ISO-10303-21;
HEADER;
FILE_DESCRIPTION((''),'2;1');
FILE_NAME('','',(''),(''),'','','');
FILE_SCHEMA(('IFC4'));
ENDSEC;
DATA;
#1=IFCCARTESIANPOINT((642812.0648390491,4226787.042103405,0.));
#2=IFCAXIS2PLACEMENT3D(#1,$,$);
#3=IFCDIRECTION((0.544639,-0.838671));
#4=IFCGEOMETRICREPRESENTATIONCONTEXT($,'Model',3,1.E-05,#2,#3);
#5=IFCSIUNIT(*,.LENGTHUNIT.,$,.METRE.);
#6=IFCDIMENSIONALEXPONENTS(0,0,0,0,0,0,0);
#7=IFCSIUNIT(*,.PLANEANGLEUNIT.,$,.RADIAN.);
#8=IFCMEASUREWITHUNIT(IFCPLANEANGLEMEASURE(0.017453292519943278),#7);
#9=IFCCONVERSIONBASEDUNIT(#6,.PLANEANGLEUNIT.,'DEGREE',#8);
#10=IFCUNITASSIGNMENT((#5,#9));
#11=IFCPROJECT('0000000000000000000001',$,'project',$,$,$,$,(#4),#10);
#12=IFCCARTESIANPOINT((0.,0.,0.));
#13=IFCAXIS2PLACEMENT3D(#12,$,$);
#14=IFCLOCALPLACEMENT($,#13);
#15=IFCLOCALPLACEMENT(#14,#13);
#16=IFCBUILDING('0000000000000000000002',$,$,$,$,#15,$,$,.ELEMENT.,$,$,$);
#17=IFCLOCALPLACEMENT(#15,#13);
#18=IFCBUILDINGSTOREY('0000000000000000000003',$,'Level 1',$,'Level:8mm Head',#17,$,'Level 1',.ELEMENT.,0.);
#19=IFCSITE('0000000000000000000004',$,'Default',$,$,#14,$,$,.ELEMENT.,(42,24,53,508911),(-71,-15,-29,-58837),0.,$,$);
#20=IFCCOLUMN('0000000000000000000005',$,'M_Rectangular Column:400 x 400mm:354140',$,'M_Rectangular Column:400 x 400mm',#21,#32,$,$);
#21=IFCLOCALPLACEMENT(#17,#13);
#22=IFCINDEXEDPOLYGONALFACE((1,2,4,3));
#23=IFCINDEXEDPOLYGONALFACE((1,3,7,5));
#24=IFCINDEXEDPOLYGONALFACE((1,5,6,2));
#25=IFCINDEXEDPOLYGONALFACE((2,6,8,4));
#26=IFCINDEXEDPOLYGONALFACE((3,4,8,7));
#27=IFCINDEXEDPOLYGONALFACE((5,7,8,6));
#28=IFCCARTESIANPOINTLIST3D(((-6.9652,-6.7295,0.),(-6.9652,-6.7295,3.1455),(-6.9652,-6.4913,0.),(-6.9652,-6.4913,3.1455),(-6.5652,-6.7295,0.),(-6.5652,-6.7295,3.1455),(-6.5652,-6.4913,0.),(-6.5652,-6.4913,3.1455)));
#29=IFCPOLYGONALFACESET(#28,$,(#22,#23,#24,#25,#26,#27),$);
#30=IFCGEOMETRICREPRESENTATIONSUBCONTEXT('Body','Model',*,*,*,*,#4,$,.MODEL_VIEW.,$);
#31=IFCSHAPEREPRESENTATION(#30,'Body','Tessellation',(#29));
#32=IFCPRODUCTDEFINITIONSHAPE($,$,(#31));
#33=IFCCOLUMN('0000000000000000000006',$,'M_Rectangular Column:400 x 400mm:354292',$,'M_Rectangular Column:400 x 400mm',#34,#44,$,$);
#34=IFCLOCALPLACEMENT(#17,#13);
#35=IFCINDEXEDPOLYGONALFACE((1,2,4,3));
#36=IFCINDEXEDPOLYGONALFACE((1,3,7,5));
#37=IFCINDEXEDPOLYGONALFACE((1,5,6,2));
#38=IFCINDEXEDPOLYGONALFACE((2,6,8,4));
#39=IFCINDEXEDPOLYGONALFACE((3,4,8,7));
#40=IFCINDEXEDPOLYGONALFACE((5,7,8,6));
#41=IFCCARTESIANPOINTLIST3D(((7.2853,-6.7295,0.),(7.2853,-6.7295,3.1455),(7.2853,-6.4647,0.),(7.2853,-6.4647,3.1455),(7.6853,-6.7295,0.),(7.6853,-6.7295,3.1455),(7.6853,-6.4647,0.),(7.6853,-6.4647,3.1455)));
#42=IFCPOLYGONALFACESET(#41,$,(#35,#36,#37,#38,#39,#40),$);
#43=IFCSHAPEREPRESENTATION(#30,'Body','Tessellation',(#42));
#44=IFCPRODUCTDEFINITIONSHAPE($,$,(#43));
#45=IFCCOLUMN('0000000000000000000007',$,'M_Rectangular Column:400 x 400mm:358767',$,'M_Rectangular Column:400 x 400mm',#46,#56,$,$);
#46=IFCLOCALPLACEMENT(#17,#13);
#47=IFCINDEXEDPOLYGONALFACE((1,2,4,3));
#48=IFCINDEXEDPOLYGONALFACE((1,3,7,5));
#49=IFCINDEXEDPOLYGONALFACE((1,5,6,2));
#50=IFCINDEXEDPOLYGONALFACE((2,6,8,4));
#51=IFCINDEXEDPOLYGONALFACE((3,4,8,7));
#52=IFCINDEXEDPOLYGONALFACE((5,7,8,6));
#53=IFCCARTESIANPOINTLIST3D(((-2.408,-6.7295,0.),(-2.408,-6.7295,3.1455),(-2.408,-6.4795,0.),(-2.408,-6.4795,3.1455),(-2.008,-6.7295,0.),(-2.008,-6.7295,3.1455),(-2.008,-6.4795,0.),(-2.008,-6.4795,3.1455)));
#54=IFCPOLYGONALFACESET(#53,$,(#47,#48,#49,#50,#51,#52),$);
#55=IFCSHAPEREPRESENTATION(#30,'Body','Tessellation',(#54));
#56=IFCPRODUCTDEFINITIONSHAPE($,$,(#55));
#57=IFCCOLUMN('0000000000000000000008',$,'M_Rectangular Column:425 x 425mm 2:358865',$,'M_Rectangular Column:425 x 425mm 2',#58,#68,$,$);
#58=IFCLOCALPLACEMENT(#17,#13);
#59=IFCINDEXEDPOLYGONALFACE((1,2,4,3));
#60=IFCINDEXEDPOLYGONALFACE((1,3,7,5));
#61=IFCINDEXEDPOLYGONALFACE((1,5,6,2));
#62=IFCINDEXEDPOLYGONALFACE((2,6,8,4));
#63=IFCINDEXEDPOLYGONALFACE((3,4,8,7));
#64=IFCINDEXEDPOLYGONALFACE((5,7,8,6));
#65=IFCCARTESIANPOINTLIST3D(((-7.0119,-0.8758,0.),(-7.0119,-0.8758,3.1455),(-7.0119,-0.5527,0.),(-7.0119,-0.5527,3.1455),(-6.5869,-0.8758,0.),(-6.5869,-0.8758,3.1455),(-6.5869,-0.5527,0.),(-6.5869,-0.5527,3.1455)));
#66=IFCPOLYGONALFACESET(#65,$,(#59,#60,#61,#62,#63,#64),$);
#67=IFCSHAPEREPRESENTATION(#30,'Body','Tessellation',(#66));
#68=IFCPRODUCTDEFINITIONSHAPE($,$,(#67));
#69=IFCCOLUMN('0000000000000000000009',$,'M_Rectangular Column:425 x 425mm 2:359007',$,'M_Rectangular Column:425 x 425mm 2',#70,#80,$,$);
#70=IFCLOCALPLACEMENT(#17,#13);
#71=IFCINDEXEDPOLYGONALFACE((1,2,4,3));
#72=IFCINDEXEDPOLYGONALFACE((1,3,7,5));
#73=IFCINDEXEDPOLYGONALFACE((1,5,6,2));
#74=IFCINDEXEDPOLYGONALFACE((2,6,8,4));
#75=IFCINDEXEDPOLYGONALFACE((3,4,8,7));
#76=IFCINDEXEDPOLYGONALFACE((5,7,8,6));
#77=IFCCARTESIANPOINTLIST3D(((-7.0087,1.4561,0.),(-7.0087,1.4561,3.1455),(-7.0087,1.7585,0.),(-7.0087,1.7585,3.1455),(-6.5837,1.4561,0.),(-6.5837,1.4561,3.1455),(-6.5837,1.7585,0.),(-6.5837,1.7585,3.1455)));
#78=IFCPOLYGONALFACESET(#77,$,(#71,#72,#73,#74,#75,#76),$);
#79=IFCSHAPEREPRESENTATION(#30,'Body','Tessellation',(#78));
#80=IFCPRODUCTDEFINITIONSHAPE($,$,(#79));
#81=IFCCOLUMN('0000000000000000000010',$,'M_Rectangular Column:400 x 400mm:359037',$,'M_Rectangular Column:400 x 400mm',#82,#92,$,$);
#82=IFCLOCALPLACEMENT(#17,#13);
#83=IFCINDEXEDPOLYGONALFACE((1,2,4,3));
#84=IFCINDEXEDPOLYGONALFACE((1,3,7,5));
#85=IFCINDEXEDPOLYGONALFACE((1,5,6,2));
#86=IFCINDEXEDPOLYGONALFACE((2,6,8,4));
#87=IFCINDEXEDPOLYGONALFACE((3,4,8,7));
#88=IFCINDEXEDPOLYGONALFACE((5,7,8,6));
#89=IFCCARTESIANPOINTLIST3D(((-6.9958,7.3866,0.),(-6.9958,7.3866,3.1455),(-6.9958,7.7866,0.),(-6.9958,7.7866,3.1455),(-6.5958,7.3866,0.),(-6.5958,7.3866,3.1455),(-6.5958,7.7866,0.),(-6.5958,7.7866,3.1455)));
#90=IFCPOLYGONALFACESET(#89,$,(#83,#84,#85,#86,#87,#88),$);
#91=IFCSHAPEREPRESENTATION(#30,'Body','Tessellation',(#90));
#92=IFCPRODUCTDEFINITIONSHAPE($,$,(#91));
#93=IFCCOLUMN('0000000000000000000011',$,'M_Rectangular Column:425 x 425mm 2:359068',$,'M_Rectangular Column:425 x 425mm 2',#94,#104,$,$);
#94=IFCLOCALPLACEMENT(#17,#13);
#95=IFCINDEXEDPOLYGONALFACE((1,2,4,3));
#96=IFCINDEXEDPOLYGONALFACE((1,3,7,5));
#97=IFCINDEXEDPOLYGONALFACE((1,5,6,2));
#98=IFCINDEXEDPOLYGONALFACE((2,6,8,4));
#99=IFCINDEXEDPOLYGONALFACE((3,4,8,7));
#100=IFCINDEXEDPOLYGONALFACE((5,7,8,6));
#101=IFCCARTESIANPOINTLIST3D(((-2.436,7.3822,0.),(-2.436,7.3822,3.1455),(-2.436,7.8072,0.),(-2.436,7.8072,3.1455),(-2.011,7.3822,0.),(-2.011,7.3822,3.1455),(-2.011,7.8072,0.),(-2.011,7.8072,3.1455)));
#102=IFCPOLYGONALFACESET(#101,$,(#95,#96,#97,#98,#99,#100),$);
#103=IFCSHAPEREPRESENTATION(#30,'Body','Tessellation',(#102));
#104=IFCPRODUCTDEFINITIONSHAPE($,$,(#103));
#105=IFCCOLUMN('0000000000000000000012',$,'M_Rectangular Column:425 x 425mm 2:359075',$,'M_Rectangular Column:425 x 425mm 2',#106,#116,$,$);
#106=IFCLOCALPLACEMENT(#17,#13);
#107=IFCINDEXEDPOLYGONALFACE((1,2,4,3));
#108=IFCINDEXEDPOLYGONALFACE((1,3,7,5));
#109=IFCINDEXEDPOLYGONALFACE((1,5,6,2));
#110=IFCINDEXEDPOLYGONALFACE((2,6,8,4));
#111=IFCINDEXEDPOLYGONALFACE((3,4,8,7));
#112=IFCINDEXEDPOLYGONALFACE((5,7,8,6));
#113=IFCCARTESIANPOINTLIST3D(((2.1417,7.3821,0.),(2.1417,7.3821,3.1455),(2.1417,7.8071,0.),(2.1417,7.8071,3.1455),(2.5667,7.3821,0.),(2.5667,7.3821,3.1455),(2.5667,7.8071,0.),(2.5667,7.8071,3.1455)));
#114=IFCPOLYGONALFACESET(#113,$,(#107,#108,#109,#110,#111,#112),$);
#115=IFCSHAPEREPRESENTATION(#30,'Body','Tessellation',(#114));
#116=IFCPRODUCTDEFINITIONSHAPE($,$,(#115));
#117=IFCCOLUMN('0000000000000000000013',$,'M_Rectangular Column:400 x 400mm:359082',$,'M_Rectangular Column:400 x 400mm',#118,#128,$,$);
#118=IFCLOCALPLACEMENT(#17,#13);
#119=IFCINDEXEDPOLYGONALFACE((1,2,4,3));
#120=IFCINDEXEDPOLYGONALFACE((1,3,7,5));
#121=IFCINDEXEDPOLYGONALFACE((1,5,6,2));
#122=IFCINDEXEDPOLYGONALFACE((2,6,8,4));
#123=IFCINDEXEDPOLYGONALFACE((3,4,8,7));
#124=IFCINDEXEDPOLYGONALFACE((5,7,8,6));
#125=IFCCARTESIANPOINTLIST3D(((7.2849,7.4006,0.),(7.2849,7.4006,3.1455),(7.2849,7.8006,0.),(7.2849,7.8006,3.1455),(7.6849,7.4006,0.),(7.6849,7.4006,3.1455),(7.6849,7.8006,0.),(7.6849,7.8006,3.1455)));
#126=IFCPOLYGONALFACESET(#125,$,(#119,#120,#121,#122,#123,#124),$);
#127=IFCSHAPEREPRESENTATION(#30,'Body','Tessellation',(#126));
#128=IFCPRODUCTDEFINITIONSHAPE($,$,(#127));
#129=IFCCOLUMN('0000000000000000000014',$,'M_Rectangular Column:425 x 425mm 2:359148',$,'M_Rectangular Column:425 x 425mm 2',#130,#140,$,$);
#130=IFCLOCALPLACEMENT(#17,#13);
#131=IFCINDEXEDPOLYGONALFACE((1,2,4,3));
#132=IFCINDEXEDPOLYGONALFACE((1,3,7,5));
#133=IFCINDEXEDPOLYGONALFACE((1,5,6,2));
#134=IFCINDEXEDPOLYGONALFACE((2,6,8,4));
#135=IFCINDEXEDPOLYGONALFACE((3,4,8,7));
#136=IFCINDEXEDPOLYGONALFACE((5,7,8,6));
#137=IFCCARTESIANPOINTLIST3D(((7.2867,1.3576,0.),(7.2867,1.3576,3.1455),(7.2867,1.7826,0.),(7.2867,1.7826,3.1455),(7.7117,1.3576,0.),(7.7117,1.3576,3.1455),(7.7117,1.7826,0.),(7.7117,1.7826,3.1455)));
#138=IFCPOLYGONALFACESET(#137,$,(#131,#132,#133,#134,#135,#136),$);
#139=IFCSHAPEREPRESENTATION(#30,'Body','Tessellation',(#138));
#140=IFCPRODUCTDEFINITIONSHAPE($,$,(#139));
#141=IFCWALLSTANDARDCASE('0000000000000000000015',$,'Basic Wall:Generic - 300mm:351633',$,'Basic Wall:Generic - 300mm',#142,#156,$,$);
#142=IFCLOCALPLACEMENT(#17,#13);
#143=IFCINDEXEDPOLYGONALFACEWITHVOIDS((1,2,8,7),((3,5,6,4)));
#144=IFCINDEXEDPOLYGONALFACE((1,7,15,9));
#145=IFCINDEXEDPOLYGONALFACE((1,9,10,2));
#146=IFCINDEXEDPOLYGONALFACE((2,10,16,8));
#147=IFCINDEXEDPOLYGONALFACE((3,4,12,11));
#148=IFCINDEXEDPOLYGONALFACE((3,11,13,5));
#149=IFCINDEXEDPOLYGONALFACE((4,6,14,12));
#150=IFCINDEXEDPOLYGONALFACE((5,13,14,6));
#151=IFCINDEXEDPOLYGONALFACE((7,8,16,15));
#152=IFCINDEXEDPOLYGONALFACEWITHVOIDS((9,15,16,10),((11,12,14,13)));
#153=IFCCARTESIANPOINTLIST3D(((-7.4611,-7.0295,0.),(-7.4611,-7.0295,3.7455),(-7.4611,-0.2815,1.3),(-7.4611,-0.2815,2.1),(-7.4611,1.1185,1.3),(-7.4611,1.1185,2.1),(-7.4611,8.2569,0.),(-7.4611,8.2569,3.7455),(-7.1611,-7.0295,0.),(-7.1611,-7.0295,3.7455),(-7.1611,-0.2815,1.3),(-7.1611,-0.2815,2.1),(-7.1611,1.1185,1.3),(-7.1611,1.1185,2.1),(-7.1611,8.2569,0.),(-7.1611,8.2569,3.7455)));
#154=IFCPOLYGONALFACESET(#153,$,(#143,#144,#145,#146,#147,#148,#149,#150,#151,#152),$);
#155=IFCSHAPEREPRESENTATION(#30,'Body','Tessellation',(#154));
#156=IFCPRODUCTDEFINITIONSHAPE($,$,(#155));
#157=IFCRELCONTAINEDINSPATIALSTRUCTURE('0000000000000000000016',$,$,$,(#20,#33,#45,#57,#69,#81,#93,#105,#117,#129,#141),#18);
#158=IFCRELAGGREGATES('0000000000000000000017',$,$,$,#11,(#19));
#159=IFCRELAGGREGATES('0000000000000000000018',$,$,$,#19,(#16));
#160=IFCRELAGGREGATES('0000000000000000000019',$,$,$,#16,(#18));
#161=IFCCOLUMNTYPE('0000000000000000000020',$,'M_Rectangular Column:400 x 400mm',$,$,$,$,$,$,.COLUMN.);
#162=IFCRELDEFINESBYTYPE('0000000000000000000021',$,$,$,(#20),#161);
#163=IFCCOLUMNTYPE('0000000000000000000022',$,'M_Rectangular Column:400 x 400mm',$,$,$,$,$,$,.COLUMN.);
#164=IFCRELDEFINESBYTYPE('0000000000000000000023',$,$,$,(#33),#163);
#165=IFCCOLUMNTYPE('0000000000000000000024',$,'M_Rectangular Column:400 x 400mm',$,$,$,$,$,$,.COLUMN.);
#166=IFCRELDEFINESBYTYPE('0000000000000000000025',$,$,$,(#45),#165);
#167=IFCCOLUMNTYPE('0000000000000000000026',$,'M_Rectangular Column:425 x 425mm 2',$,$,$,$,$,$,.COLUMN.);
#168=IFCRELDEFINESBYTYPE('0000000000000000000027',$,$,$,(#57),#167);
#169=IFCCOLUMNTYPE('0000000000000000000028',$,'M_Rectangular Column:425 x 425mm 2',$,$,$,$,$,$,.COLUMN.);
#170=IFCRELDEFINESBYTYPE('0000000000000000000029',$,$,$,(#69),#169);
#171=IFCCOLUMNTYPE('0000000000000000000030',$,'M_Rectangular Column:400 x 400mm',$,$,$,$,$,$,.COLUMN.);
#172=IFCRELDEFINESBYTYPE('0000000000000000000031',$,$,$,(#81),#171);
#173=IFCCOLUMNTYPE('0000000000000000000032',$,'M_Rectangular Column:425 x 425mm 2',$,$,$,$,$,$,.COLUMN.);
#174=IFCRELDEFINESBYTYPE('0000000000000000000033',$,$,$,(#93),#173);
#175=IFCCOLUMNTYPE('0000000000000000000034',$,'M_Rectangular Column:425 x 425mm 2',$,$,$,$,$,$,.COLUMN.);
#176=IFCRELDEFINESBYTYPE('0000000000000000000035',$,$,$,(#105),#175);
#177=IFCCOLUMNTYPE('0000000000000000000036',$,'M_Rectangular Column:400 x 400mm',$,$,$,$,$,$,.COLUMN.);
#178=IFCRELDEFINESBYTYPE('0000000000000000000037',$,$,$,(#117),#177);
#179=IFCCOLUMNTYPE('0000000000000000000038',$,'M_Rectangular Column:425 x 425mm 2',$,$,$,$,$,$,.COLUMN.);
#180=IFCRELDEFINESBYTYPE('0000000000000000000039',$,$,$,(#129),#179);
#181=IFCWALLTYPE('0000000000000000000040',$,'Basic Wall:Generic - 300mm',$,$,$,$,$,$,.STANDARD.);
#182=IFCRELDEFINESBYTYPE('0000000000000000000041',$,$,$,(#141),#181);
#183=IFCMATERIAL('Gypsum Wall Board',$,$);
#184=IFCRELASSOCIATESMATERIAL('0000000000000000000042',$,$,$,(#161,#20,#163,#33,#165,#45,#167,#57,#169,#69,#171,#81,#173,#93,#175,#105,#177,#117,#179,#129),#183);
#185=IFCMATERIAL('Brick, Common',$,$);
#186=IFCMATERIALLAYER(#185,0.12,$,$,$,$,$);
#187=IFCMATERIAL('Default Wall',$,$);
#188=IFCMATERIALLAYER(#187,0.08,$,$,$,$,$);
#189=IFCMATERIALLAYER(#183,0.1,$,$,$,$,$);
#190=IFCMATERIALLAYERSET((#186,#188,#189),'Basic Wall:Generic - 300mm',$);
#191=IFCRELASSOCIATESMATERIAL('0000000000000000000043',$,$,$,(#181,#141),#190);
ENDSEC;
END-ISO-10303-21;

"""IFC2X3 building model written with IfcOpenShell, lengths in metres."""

from ifc_helpers import new_model, entity, si_unit, converted_unit, direction, frame, frame_2d, origin, origin_2d_with_axis, place, context, subcontext, project, spatial, rectangle, extrude, clip, halfspace, source, transform, mapped, material, layer, layer_set, layer_usage, type_object, type_shapes, element, save


model = new_model("IFC2X3")

# Units and contexts
model_context = context("Model", 3, precision=1e-05, world=frame((642812.0648390491, 4226787.042103405, 0.0)), true_north=direction((0.544639, -0.838671)))
body_context = subcontext(model_context, "Body", "Model", "MODEL_VIEW")
ifc_project = project(units=[si_unit("LENGTHUNIT", "METRE"), converted_unit("PLANEANGLEUNIT", "DEGREE", entity("IfcPlaneAngleMeasure", 0.017453292519943278), si_unit("PLANEANGLEUNIT", "RADIAN"), dimensions=[0, 0, 0, 0, 0, 0, 0])], contexts=[model_context])

# Site, building, storey
site_placement = place(None, origin())
site = spatial("IfcSite", under=ifc_project, at=site_placement, Name="Default", CompositionType="ELEMENT", RefLatitude=(42, 24, 53, 508911), RefLongitude=(-71, -15, -29, -58837), RefElevation=0.0)
building_placement = place(site_placement, origin())
building = spatial("IfcBuilding", under=site, at=building_placement, CompositionType="ELEMENT")
storey_placement = place(building_placement, origin())
storey = spatial("IfcBuildingStorey", under=building, at=storey_placement, Name="Level 1", ObjectType="Level:8mm Head", LongName="Level 1", CompositionType="ELEMENT", Elevation=0.0)

# Columns
ifc_material_1 = material(Name="Gypsum Wall Board")
column_type_1 = type_object("IfcColumnType", Name="M_Rectangular Column:400 x 400mm", PredefinedType="COLUMN", material=ifc_material_1)
shared_shape_1 = source(origin(), body_context, "Body", "SweptSolid", [
    extrude(rectangle(XDim=0.2382, YDim=0.4, at=origin_2d_with_axis()), frame((-6.7652, -6.6104, 0.0), z_axis=(0.0, 0.0, 1.0), x_axis=(0.0, -1.0, 0.0)), (0.0, 0.0, 1.0), 3.1455),
])
type_shapes(column_type_1, [shared_shape_1])
column_1_placement = place(storey_placement, origin())
element("IfcColumn", 1, at=column_1_placement, inside=storey, type_object=column_type_1, material=ifc_material_1, Name="M_Rectangular Column:400 x 400mm:354140", ObjectType="M_Rectangular Column:400 x 400mm", context=body_context, shape_type="MappedRepresentation", body=[
    mapped(shared_shape_1, transform((0.0, 0.0, 0.0), scale=1.0)),
])
column_type_2 = type_object("IfcColumnType", Name="M_Rectangular Column:400 x 400mm", PredefinedType="COLUMN", material=ifc_material_1)
shared_shape_2 = source(origin(), body_context, "Body", "SweptSolid", [
    extrude(rectangle(XDim=0.2647, YDim=0.4, at=origin_2d_with_axis()), frame((7.4853, -6.5971, 0.0), z_axis=(0.0, 0.0, 1.0), x_axis=(0.0, -1.0, 0.0)), (0.0, 0.0, 1.0), 3.1455),
])
type_shapes(column_type_2, [shared_shape_2])
column_2_placement = place(storey_placement, origin())
element("IfcColumn", 2, at=column_2_placement, inside=storey, type_object=column_type_2, material=ifc_material_1, Name="M_Rectangular Column:400 x 400mm:354292", ObjectType="M_Rectangular Column:400 x 400mm", context=body_context, shape_type="MappedRepresentation", body=[
    mapped(shared_shape_2, transform((0.0, 0.0, 0.0), scale=1.0)),
])
column_type_3 = type_object("IfcColumnType", Name="M_Rectangular Column:400 x 400mm", PredefinedType="COLUMN", material=ifc_material_1)
shared_shape_3 = source(origin(), body_context, "Body", "SweptSolid", [
    extrude(rectangle(XDim=0.25, YDim=0.4, at=frame_2d((0.0, 0.0), x_axis=(1.0, 0.0))), frame((-2.208, -6.6045, 0.0), z_axis=(0.0, 0.0, 1.0), x_axis=(0.0, -1.0, 0.0)), (0.0, 0.0, 1.0), 3.1455),
])
type_shapes(column_type_3, [shared_shape_3])
column_3_placement = place(storey_placement, origin())
element("IfcColumn", 3, at=column_3_placement, inside=storey, type_object=column_type_3, material=ifc_material_1, Name="M_Rectangular Column:400 x 400mm:358767", ObjectType="M_Rectangular Column:400 x 400mm", context=body_context, shape_type="MappedRepresentation", body=[
    mapped(shared_shape_3, transform((0.0, 0.0, 0.0), scale=1.0)),
])
column_type_4 = type_object("IfcColumnType", Name="M_Rectangular Column:425 x 425mm 2", PredefinedType="COLUMN", material=ifc_material_1)
shared_shape_4 = source(origin(), body_context, "Body", "SweptSolid", [
    extrude(rectangle(XDim=0.3232, YDim=0.425, at=frame_2d((0.0, 0.0), x_axis=(1.0, 0.0))), frame((-6.7994, -0.7142, 0.0), z_axis=(0.0, 0.0, 1.0), x_axis=(0.0, 1.0, 0.0)), (0.0, 0.0, 1.0), 3.1455),
])
type_shapes(column_type_4, [shared_shape_4])
column_4_placement = place(storey_placement, origin())
element("IfcColumn", 4, at=column_4_placement, inside=storey, type_object=column_type_4, material=ifc_material_1, Name="M_Rectangular Column:425 x 425mm 2:358865", ObjectType="M_Rectangular Column:425 x 425mm 2", context=body_context, shape_type="MappedRepresentation", body=[
    mapped(shared_shape_4, transform((0.0, 0.0, 0.0), scale=1.0)),
])
column_type_5 = type_object("IfcColumnType", Name="M_Rectangular Column:425 x 425mm 2", PredefinedType="COLUMN", material=ifc_material_1)
shared_shape_5 = source(origin(), body_context, "Body", "SweptSolid", [
    extrude(rectangle(XDim=0.3024, YDim=0.425, at=frame_2d((0.0, 0.0), x_axis=(1.0, 0.0))), frame((-6.7962, 1.6073, 0.0), z_axis=(0.0, 0.0, 1.0), x_axis=(0.0, -1.0, 0.0)), (0.0, 0.0, 1.0), 3.1455),
])
type_shapes(column_type_5, [shared_shape_5])
column_5_placement = place(storey_placement, origin())
element("IfcColumn", 5, at=column_5_placement, inside=storey, type_object=column_type_5, material=ifc_material_1, Name="M_Rectangular Column:425 x 425mm 2:359007", ObjectType="M_Rectangular Column:425 x 425mm 2", context=body_context, shape_type="MappedRepresentation", body=[
    mapped(shared_shape_5, transform((0.0, 0.0, 0.0), scale=1.0)),
])
column_type_6 = type_object("IfcColumnType", Name="M_Rectangular Column:400 x 400mm", PredefinedType="COLUMN", material=ifc_material_1)
shared_shape_6 = source(origin(), body_context, "Body", "SweptSolid", [
    extrude(rectangle(XDim=0.4, YDim=0.4, at=frame_2d((0.0, 0.0), x_axis=(1.0, 0.0))), frame((-6.7958, 7.5866, 0.0), z_axis=(0.0, 0.0, 1.0), x_axis=(-1.0, 0.0, 0.0)), (0.0, 0.0, 1.0), 3.1455),
])
type_shapes(column_type_6, [shared_shape_6])
column_6_placement = place(storey_placement, origin())
element("IfcColumn", 6, at=column_6_placement, inside=storey, type_object=column_type_6, material=ifc_material_1, Name="M_Rectangular Column:400 x 400mm:359037", ObjectType="M_Rectangular Column:400 x 400mm", context=body_context, shape_type="MappedRepresentation", body=[
    mapped(shared_shape_6, transform((0.0, 0.0, 0.0), scale=1.0)),
])
column_type_7 = type_object("IfcColumnType", Name="M_Rectangular Column:425 x 425mm 2", PredefinedType="COLUMN", material=ifc_material_1)
shared_shape_7 = source(origin(), body_context, "Body", "SweptSolid", [
    extrude(rectangle(XDim=0.425, YDim=0.425, at=origin_2d_with_axis()), frame((-2.2235, 7.5947, 0.0), z_axis=(0.0, 0.0, 1.0), x_axis=(-1.0, 0.0, 0.0)), (0.0, 0.0, 1.0), 3.1455),
])
type_shapes(column_type_7, [shared_shape_7])
column_7_placement = place(storey_placement, origin())
element("IfcColumn", 7, at=column_7_placement, inside=storey, type_object=column_type_7, material=ifc_material_1, Name="M_Rectangular Column:425 x 425mm 2:359068", ObjectType="M_Rectangular Column:425 x 425mm 2", context=body_context, shape_type="MappedRepresentation", body=[
    mapped(shared_shape_7, transform((0.0, 0.0, 0.0), scale=1.0)),
])
column_type_8 = type_object("IfcColumnType", Name="M_Rectangular Column:425 x 425mm 2", PredefinedType="COLUMN", material=ifc_material_1)
shared_shape_8 = source(origin(), body_context, "Body", "SweptSolid", [
    extrude(rectangle(XDim=0.425, YDim=0.425, at=frame_2d((0.0, 0.0), x_axis=(1.0, 0.0))), frame((2.3542, 7.5946, 0.0), z_axis=(0.0, 0.0, 1.0), x_axis=(-1.0, 0.0, 0.0)), (0.0, 0.0, 1.0), 3.1455),
])
type_shapes(column_type_8, [shared_shape_8])
column_8_placement = place(storey_placement, origin())
element("IfcColumn", 8, at=column_8_placement, inside=storey, type_object=column_type_8, material=ifc_material_1, Name="M_Rectangular Column:425 x 425mm 2:359075", ObjectType="M_Rectangular Column:425 x 425mm 2", context=body_context, shape_type="MappedRepresentation", body=[
    mapped(shared_shape_8, transform((0.0, 0.0, 0.0), scale=1.0)),
])
column_type_9 = type_object("IfcColumnType", Name="M_Rectangular Column:400 x 400mm", PredefinedType="COLUMN", material=ifc_material_1)
shared_shape_9 = source(origin(), body_context, "Body", "SweptSolid", [
    extrude(rectangle(XDim=0.4, YDim=0.4, at=frame_2d((0.0, 0.0), x_axis=(1.0, 0.0))), frame((7.4849, 7.6006, 0.0), z_axis=(0.0, 0.0, 1.0), x_axis=(-1.0, 0.0, 0.0)), (0.0, 0.0, 1.0), 3.1455),
])
type_shapes(column_type_9, [shared_shape_9])
column_9_placement = place(storey_placement, origin())
element("IfcColumn", 9, at=column_9_placement, inside=storey, type_object=column_type_9, material=ifc_material_1, Name="M_Rectangular Column:400 x 400mm:359082", ObjectType="M_Rectangular Column:400 x 400mm", context=body_context, shape_type="MappedRepresentation", body=[
    mapped(shared_shape_9, transform((0.0, 0.0, 0.0), scale=1.0)),
])
column_type_10 = type_object("IfcColumnType", Name="M_Rectangular Column:425 x 425mm 2", PredefinedType="COLUMN", material=ifc_material_1)
shared_shape_10 = source(origin(), body_context, "Body", "SweptSolid", [
    extrude(rectangle(XDim=0.425, YDim=0.425, at=frame_2d((0.0, 0.0), x_axis=(1.0, 0.0))), frame((7.4992, 1.5701, 0.0), z_axis=(0.0, 0.0, 1.0), x_axis=(-1.0, 0.0, 0.0)), (0.0, 0.0, 1.0), 3.1455),
])
type_shapes(column_type_10, [shared_shape_10])
column_10_placement = place(storey_placement, origin())
element("IfcColumn", 10, at=column_10_placement, inside=storey, type_object=column_type_10, material=ifc_material_1, Name="M_Rectangular Column:425 x 425mm 2:359148", ObjectType="M_Rectangular Column:425 x 425mm 2", context=body_context, shape_type="MappedRepresentation", body=[
    mapped(shared_shape_10, transform((0.0, 0.0, 0.0), scale=1.0)),
])

# Wall, opening
ifc_material_2 = material(Name="Brick, Common")
ifc_layer_1 = layer(ifc_material_2, 0.12)
ifc_material_3 = material(Name="Default Wall")
ifc_layer_2 = layer(ifc_material_3, 0.08)
ifc_layer_3 = layer(ifc_material_1, 0.1)
ifc_layer_set_1 = layer_set([ifc_layer_1, ifc_layer_2, ifc_layer_3], Name="Basic Wall:Generic - 300mm")
ifc_layer_usage_1 = layer_usage(ifc_layer_set_1, "AXIS2", "POSITIVE", -0.15)
wall_type_1 = type_object("IfcWallType", Name="Basic Wall:Generic - 300mm", PredefinedType="STANDARD", material=ifc_layer_set_1)
wall_1_placement = place(storey_placement, frame((-7.3111, 8.2569, 0.0), z_axis=(0.0, 0.0, 1.0), x_axis=(0.0, -1.0, 0.0)))
wall_1 = element("IfcWallStandardCase", 11, at=wall_1_placement, inside=storey, type_object=wall_type_1, material=ifc_layer_usage_1, Name="Basic Wall:Generic - 300mm:351633", ObjectType="Basic Wall:Generic - 300mm", context=body_context, shape_type="Clipping", body=[
    clip(extrude(rectangle(XDim=15.2864, YDim=0.3, at=frame_2d((7.6432, 0.0), x_axis=(-1.0, 0.0))), origin(), (0.0, 0.0, 1.0), 3.7455), halfspace(origin(), True)),
])
opening_1_placement = place(wall_1_placement, frame((8.5384, 0.15, 1.3)))
element("IfcOpeningElement", 12, at=opening_1_placement, cuts=wall_1, ObjectType="Opening", context=body_context, shape_type="SweptSolid", body=[
    extrude(rectangle(XDim=0.8, YDim=1.4, at=frame_2d((0.4, 0.7), x_axis=(-1.0, 0.0))), frame((0.0, 0.0, 0.0), z_axis=(0.0, -1.0, 0.0), x_axis=(0.0, 0.0, 1.0)), (0.0, 0.0, 1.0), 0.3),
])

save(model, "model.ifc")
